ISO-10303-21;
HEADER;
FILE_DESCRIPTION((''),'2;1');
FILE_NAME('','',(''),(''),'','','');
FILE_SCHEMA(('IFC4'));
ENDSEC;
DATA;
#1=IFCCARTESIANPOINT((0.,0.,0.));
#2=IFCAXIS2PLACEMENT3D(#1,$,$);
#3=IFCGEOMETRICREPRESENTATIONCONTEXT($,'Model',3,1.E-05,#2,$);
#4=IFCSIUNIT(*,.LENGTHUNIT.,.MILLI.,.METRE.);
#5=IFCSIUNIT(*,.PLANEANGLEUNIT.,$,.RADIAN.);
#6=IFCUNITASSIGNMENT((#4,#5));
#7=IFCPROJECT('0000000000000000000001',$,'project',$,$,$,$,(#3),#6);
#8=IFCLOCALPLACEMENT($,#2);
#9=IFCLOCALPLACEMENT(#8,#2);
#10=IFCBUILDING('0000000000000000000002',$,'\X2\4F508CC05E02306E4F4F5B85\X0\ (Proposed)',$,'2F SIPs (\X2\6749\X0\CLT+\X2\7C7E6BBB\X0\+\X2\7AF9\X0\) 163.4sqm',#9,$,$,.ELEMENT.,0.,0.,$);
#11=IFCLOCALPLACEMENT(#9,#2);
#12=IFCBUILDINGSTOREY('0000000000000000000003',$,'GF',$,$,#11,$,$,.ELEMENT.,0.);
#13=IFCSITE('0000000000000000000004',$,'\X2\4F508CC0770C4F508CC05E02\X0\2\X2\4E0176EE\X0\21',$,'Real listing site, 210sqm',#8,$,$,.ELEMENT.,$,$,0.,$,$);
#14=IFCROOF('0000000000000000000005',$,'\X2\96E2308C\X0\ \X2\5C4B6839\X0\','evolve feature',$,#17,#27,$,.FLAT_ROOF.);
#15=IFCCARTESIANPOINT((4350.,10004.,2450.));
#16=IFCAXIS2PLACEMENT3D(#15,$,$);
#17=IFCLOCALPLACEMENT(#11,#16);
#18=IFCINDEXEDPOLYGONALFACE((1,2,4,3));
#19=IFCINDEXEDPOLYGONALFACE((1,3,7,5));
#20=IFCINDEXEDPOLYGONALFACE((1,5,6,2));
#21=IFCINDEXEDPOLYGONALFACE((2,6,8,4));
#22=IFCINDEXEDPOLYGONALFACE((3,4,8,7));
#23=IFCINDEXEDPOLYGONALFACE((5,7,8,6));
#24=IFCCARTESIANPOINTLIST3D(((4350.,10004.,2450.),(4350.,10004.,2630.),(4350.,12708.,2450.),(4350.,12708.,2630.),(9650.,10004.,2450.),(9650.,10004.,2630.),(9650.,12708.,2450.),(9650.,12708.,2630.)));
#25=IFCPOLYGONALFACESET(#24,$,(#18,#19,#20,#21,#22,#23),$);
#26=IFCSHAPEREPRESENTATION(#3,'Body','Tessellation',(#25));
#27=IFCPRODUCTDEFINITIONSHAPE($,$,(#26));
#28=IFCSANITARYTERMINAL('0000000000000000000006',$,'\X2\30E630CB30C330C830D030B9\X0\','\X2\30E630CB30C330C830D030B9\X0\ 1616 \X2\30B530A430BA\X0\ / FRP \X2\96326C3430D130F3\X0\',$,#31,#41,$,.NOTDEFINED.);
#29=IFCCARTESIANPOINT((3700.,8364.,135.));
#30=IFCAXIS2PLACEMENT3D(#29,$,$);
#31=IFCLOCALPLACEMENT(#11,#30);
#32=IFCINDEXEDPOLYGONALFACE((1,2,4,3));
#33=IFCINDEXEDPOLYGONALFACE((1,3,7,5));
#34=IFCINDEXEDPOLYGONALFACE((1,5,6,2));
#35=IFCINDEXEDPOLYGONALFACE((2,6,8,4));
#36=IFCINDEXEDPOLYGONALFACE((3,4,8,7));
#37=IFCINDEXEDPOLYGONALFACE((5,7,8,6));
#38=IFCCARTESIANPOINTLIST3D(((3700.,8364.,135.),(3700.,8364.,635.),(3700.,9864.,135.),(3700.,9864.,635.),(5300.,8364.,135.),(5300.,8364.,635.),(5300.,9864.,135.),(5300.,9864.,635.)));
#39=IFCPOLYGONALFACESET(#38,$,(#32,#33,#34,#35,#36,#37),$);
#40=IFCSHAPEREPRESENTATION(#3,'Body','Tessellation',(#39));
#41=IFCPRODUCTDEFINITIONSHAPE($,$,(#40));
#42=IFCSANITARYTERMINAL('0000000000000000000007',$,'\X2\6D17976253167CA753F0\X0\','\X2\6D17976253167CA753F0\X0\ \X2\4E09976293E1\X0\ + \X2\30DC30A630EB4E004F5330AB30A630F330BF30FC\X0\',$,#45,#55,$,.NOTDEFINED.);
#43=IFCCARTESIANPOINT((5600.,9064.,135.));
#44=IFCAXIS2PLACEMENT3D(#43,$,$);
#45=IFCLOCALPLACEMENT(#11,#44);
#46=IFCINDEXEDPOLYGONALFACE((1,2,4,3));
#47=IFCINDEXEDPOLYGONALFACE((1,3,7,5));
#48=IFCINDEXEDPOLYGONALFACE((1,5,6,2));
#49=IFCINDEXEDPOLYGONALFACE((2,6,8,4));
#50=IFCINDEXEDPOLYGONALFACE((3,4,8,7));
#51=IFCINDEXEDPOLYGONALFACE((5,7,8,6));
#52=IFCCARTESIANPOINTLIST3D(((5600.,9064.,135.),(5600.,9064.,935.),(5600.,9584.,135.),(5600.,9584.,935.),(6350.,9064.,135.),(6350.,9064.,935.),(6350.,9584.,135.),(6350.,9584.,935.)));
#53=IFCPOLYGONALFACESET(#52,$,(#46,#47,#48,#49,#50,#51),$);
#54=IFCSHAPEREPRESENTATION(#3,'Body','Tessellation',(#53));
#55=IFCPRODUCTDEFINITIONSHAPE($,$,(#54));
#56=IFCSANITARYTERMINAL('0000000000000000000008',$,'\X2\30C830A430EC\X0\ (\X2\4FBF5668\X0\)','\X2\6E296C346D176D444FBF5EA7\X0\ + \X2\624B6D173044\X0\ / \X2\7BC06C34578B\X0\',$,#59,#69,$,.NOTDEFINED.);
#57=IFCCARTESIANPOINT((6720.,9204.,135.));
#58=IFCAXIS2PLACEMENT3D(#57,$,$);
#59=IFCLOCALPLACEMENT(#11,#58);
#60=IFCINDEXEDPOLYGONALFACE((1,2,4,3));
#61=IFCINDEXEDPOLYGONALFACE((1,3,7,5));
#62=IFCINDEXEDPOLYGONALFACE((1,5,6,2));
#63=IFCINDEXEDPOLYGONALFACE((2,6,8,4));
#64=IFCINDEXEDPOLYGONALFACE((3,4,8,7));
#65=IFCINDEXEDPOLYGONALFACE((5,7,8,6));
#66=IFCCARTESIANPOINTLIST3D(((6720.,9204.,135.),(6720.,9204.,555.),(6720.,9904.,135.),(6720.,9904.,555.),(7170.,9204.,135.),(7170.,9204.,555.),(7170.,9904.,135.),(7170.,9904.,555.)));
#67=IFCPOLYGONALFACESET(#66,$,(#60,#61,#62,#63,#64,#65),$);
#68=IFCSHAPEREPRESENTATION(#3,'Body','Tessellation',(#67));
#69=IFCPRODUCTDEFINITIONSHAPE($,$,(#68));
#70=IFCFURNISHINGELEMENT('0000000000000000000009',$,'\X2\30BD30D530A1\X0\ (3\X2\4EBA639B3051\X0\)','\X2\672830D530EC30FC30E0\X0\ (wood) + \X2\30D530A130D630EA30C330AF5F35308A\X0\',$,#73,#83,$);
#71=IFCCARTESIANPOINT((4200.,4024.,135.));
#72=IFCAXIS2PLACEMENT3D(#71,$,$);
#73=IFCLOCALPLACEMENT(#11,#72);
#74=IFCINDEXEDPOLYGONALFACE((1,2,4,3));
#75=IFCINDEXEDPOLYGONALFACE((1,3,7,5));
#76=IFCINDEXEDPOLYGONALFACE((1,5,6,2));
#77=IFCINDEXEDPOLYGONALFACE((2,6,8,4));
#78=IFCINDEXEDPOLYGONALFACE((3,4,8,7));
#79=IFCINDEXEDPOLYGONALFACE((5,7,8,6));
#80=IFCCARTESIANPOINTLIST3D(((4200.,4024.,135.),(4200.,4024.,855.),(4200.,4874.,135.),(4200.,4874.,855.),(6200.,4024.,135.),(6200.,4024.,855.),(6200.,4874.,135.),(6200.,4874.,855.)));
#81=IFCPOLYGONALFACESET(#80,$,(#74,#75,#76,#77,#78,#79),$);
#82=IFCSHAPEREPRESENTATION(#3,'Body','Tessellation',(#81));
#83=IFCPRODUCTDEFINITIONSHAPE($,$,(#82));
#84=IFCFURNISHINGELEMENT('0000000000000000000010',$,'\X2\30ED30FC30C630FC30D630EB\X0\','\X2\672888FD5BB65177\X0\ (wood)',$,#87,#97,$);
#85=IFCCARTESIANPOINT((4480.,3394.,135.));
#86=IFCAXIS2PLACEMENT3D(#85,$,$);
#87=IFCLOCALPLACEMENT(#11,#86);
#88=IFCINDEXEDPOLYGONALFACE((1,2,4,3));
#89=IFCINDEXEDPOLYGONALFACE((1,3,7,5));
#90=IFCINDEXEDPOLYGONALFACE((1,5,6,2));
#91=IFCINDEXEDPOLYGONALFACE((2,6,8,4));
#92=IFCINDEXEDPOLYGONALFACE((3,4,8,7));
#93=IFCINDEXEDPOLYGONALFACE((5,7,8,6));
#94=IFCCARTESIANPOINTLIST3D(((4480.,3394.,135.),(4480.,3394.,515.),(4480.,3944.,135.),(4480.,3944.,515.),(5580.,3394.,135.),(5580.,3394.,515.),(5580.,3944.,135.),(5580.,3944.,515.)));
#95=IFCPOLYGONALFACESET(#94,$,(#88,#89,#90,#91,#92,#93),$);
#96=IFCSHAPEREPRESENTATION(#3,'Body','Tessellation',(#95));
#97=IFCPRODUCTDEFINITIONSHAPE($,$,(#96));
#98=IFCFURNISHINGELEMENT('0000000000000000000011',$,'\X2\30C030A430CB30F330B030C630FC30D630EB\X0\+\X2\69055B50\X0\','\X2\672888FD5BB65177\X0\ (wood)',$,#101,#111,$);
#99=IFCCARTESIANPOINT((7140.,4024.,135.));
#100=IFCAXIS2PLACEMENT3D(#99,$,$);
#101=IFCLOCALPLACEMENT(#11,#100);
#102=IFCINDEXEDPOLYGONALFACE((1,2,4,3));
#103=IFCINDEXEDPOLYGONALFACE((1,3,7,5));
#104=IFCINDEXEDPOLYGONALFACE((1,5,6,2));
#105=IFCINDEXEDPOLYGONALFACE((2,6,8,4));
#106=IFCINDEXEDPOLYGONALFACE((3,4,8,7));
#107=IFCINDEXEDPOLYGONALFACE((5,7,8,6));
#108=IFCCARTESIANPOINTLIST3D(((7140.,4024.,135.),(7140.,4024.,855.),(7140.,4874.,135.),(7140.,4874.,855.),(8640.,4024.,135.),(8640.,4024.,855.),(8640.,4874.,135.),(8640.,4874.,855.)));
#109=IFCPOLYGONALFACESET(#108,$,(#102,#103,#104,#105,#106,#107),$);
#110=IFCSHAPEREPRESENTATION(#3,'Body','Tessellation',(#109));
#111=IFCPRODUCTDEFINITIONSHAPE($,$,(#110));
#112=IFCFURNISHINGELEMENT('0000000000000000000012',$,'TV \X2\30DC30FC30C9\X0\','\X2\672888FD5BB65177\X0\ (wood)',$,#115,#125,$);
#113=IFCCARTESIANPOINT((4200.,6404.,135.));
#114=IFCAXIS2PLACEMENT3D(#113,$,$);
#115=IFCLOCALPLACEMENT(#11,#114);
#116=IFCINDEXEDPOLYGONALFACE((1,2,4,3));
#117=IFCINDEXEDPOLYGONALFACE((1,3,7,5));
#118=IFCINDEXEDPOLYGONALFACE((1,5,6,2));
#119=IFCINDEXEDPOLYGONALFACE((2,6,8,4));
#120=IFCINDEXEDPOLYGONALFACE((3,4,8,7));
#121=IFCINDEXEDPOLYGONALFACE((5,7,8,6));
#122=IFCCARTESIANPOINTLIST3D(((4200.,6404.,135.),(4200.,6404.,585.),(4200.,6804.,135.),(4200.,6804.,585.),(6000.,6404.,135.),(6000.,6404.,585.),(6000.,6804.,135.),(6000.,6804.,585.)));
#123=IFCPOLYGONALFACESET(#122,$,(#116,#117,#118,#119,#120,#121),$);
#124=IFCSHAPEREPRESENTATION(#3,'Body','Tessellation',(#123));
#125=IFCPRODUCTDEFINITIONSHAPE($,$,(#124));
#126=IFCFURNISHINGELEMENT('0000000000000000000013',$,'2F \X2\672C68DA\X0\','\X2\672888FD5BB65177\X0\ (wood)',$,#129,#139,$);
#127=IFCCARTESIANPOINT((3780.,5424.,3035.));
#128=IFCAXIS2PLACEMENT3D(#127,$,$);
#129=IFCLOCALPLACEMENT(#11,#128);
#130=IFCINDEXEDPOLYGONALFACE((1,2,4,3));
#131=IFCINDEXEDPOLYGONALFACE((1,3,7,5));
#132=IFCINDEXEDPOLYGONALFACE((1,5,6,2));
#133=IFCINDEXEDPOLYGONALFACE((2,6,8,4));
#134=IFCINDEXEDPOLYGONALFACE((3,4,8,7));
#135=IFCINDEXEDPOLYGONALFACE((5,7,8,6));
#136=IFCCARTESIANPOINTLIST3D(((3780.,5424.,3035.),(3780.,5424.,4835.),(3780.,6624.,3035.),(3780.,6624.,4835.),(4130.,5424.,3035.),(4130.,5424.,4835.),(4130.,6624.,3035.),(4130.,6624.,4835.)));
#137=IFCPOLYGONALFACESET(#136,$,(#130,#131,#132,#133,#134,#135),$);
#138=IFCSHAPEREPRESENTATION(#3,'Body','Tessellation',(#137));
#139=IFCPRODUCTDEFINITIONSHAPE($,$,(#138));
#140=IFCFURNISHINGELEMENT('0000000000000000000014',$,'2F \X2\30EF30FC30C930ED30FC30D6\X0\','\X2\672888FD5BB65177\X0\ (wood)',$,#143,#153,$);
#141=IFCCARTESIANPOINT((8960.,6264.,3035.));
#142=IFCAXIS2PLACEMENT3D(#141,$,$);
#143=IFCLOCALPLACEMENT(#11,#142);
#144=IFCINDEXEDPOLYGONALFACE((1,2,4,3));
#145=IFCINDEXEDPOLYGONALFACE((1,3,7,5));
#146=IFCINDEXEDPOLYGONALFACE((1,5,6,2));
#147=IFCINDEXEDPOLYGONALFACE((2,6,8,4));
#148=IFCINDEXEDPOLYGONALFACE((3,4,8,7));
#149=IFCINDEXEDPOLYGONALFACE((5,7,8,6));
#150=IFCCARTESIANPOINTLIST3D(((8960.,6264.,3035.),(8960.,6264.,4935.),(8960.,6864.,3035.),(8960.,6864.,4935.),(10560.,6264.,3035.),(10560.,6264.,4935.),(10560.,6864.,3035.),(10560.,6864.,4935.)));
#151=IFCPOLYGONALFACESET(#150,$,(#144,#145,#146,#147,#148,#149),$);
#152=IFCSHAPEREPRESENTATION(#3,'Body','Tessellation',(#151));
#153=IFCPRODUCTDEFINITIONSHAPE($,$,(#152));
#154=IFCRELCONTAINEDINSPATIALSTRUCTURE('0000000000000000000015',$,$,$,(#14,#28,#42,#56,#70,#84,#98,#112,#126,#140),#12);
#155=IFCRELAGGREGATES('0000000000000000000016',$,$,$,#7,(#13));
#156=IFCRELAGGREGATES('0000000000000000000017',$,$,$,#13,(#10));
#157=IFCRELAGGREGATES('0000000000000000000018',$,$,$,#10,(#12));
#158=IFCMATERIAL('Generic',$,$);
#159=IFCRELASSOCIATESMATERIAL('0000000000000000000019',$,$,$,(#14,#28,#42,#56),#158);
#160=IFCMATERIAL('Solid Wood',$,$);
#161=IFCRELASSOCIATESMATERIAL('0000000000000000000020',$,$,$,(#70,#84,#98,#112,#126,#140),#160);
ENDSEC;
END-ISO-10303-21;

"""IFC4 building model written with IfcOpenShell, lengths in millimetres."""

from ifc_helpers import new_model, si_unit, frame, frame_2d, origin, place, context, project, spatial, rectangle, extrude, material, element, save


model = new_model("IFC4")

# Units and contexts
model_context = context("Model", 3, precision=1e-05, world=origin())
ifc_project = project(units=[si_unit("LENGTHUNIT", "METRE", prefix="MILLI"), si_unit("PLANEANGLEUNIT", "RADIAN")], contexts=[model_context])

# Site, building, storey
site_placement = place(None, origin())
site = spatial("IfcSite", under=ifc_project, at=site_placement, Name="佐賀県佐賀市2丁目21", ObjectType="Real listing site, 210sqm", CompositionType="ELEMENT", RefElevation=0.0)
building_placement = place(site_placement, origin())
building = spatial("IfcBuilding", under=site, at=building_placement, Name="佐賀市の住宅 (Proposed)", ObjectType="2F SIPs (杉CLT+籾殻+竹) 163.4sqm", CompositionType="ELEMENT", ElevationOfRefHeight=0.0, ElevationOfTerrain=0.0)
storey_placement = place(building_placement, origin())
storey = spatial("IfcBuildingStorey", under=building, at=storey_placement, Name="GF", CompositionType="ELEMENT", Elevation=0.0)

# Shared definitions
ifc_material_1 = material(Name="Generic")

# Shared definitions
ifc_material_2 = material(Name="Solid Wood")

# Roof
roof_placement = place(storey_placement, frame((4350.0, 10004.0, 2450.0)))
element("IfcRoof", 1, at=roof_placement, inside=storey, material=ifc_material_1, Name="離れ 屋根", Description="evolve feature", PredefinedType="FLAT_ROOF", context=model_context, shape_type="SweptSolid", body=[
    extrude(rectangle(XDim=5300.0, YDim=2704.0, at=frame_2d((2650.0, 1352.0))), frame((4350.0, 10004.0, 2450.0)), (0.0, 0.0, 1.0), 180.0),
])

# Sanitary terminals
sanitary_terminal_1_placement = place(storey_placement, frame((3700.0, 8364.0, 135.0)))
element("IfcSanitaryTerminal", 2, at=sanitary_terminal_1_placement, inside=storey, material=ifc_material_1, Name="ユニットバス", Description="ユニットバス 1616 サイズ / FRP 防水パン", PredefinedType="NOTDEFINED", context=model_context, shape_type="SweptSolid", body=[
    extrude(rectangle(XDim=1600.0, YDim=1500.0, at=frame_2d((800.0, 750.0))), frame((3700.0, 8364.0, 135.0)), (0.0, 0.0, 1.0), 500.0),
])
sanitary_terminal_2_placement = place(storey_placement, frame((5600.0, 9064.0, 135.0)))
element("IfcSanitaryTerminal", 3, at=sanitary_terminal_2_placement, inside=storey, material=ifc_material_1, Name="洗面化粧台", Description="洗面化粧台 三面鏡 + ボウル一体カウンター", PredefinedType="NOTDEFINED", context=model_context, shape_type="SweptSolid", body=[
    extrude(rectangle(XDim=750.0, YDim=520.0, at=frame_2d((375.0, 260.0))), frame((5600.0, 9064.0, 135.0)), (0.0, 0.0, 1.0), 800.0),
])
sanitary_terminal_3_placement = place(storey_placement, frame((6720.0, 9204.0, 135.0)))
element("IfcSanitaryTerminal", 4, at=sanitary_terminal_3_placement, inside=storey, material=ifc_material_1, Name="トイレ (便器)", Description="温水洗浄便座 + 手洗い / 節水型", PredefinedType="NOTDEFINED", context=model_context, shape_type="SweptSolid", body=[
    extrude(rectangle(XDim=450.0, YDim=700.0, at=frame_2d((225.0, 350.0))), frame((6720.0, 9204.0, 135.0)), (0.0, 0.0, 1.0), 420.0),
])

# Furnishing elements
furnishing_1_placement = place(storey_placement, frame((4200.0, 4024.0, 135.0)))
element("IfcFurnishingElement", 5, at=furnishing_1_placement, inside=storey, material=ifc_material_2, Name="ソファ (3人掛け)", Description="木フレーム (wood) + ファブリック張り", context=model_context, shape_type="SweptSolid", body=[
    extrude(rectangle(XDim=2000.0, YDim=850.0, at=frame_2d((1000.0, 425.0))), frame((4200.0, 4024.0, 135.0)), (0.0, 0.0, 1.0), 720.0),
])
furnishing_2_placement = place(storey_placement, frame((4480.0, 3394.0, 135.0)))
element("IfcFurnishingElement", 6, at=furnishing_2_placement, inside=storey, material=ifc_material_2, Name="ローテーブル", Description="木製家具 (wood)", context=model_context, shape_type="SweptSolid", body=[
    extrude(rectangle(XDim=1100.0, YDim=550.0, at=frame_2d((550.0, 275.0))), frame((4480.0, 3394.0, 135.0)), (0.0, 0.0, 1.0), 380.0),
])
furnishing_3_placement = place(storey_placement, frame((7140.0, 4024.0, 135.0)))
element("IfcFurnishingElement", 7, at=furnishing_3_placement, inside=storey, material=ifc_material_2, Name="ダイニングテーブル+椅子", Description="木製家具 (wood)", context=model_context, shape_type="SweptSolid", body=[
    extrude(rectangle(XDim=1500.0, YDim=850.0, at=frame_2d((750.0, 425.0))), frame((7140.0, 4024.0, 135.0)), (0.0, 0.0, 1.0), 720.0),
])
furnishing_4_placement = place(storey_placement, frame((4200.0, 6404.0, 135.0)))
element("IfcFurnishingElement", 8, at=furnishing_4_placement, inside=storey, material=ifc_material_2, Name="TV ボード", Description="木製家具 (wood)", context=model_context, shape_type="SweptSolid", body=[
    extrude(rectangle(XDim=1800.0, YDim=400.0, at=frame_2d((900.0, 200.0))), frame((4200.0, 6404.0, 135.0)), (0.0, 0.0, 1.0), 450.0),
])
furnishing_5_placement = place(storey_placement, frame((3780.0, 5424.0, 3035.0)))
element("IfcFurnishingElement", 9, at=furnishing_5_placement, inside=storey, material=ifc_material_2, Name="2F 本棚", Description="木製家具 (wood)", context=model_context, shape_type="SweptSolid", body=[
    extrude(rectangle(XDim=350.0, YDim=1200.0, at=frame_2d((175.0, 600.0))), frame((3780.0, 5424.0, 3035.0)), (0.0, 0.0, 1.0), 1800.0),
])
furnishing_6_placement = place(storey_placement, frame((8960.0, 6264.0, 3035.0)))
element("IfcFurnishingElement", 10, at=furnishing_6_placement, inside=storey, material=ifc_material_2, Name="2F ワードローブ", Description="木製家具 (wood)", context=model_context, shape_type="SweptSolid", body=[
    extrude(rectangle(XDim=1600.0, YDim=600.0, at=frame_2d((800.0, 300.0))), frame((8960.0, 6264.0, 3035.0)), (0.0, 0.0, 1.0), 1900.0),
])

save(model, "model.ifc")
